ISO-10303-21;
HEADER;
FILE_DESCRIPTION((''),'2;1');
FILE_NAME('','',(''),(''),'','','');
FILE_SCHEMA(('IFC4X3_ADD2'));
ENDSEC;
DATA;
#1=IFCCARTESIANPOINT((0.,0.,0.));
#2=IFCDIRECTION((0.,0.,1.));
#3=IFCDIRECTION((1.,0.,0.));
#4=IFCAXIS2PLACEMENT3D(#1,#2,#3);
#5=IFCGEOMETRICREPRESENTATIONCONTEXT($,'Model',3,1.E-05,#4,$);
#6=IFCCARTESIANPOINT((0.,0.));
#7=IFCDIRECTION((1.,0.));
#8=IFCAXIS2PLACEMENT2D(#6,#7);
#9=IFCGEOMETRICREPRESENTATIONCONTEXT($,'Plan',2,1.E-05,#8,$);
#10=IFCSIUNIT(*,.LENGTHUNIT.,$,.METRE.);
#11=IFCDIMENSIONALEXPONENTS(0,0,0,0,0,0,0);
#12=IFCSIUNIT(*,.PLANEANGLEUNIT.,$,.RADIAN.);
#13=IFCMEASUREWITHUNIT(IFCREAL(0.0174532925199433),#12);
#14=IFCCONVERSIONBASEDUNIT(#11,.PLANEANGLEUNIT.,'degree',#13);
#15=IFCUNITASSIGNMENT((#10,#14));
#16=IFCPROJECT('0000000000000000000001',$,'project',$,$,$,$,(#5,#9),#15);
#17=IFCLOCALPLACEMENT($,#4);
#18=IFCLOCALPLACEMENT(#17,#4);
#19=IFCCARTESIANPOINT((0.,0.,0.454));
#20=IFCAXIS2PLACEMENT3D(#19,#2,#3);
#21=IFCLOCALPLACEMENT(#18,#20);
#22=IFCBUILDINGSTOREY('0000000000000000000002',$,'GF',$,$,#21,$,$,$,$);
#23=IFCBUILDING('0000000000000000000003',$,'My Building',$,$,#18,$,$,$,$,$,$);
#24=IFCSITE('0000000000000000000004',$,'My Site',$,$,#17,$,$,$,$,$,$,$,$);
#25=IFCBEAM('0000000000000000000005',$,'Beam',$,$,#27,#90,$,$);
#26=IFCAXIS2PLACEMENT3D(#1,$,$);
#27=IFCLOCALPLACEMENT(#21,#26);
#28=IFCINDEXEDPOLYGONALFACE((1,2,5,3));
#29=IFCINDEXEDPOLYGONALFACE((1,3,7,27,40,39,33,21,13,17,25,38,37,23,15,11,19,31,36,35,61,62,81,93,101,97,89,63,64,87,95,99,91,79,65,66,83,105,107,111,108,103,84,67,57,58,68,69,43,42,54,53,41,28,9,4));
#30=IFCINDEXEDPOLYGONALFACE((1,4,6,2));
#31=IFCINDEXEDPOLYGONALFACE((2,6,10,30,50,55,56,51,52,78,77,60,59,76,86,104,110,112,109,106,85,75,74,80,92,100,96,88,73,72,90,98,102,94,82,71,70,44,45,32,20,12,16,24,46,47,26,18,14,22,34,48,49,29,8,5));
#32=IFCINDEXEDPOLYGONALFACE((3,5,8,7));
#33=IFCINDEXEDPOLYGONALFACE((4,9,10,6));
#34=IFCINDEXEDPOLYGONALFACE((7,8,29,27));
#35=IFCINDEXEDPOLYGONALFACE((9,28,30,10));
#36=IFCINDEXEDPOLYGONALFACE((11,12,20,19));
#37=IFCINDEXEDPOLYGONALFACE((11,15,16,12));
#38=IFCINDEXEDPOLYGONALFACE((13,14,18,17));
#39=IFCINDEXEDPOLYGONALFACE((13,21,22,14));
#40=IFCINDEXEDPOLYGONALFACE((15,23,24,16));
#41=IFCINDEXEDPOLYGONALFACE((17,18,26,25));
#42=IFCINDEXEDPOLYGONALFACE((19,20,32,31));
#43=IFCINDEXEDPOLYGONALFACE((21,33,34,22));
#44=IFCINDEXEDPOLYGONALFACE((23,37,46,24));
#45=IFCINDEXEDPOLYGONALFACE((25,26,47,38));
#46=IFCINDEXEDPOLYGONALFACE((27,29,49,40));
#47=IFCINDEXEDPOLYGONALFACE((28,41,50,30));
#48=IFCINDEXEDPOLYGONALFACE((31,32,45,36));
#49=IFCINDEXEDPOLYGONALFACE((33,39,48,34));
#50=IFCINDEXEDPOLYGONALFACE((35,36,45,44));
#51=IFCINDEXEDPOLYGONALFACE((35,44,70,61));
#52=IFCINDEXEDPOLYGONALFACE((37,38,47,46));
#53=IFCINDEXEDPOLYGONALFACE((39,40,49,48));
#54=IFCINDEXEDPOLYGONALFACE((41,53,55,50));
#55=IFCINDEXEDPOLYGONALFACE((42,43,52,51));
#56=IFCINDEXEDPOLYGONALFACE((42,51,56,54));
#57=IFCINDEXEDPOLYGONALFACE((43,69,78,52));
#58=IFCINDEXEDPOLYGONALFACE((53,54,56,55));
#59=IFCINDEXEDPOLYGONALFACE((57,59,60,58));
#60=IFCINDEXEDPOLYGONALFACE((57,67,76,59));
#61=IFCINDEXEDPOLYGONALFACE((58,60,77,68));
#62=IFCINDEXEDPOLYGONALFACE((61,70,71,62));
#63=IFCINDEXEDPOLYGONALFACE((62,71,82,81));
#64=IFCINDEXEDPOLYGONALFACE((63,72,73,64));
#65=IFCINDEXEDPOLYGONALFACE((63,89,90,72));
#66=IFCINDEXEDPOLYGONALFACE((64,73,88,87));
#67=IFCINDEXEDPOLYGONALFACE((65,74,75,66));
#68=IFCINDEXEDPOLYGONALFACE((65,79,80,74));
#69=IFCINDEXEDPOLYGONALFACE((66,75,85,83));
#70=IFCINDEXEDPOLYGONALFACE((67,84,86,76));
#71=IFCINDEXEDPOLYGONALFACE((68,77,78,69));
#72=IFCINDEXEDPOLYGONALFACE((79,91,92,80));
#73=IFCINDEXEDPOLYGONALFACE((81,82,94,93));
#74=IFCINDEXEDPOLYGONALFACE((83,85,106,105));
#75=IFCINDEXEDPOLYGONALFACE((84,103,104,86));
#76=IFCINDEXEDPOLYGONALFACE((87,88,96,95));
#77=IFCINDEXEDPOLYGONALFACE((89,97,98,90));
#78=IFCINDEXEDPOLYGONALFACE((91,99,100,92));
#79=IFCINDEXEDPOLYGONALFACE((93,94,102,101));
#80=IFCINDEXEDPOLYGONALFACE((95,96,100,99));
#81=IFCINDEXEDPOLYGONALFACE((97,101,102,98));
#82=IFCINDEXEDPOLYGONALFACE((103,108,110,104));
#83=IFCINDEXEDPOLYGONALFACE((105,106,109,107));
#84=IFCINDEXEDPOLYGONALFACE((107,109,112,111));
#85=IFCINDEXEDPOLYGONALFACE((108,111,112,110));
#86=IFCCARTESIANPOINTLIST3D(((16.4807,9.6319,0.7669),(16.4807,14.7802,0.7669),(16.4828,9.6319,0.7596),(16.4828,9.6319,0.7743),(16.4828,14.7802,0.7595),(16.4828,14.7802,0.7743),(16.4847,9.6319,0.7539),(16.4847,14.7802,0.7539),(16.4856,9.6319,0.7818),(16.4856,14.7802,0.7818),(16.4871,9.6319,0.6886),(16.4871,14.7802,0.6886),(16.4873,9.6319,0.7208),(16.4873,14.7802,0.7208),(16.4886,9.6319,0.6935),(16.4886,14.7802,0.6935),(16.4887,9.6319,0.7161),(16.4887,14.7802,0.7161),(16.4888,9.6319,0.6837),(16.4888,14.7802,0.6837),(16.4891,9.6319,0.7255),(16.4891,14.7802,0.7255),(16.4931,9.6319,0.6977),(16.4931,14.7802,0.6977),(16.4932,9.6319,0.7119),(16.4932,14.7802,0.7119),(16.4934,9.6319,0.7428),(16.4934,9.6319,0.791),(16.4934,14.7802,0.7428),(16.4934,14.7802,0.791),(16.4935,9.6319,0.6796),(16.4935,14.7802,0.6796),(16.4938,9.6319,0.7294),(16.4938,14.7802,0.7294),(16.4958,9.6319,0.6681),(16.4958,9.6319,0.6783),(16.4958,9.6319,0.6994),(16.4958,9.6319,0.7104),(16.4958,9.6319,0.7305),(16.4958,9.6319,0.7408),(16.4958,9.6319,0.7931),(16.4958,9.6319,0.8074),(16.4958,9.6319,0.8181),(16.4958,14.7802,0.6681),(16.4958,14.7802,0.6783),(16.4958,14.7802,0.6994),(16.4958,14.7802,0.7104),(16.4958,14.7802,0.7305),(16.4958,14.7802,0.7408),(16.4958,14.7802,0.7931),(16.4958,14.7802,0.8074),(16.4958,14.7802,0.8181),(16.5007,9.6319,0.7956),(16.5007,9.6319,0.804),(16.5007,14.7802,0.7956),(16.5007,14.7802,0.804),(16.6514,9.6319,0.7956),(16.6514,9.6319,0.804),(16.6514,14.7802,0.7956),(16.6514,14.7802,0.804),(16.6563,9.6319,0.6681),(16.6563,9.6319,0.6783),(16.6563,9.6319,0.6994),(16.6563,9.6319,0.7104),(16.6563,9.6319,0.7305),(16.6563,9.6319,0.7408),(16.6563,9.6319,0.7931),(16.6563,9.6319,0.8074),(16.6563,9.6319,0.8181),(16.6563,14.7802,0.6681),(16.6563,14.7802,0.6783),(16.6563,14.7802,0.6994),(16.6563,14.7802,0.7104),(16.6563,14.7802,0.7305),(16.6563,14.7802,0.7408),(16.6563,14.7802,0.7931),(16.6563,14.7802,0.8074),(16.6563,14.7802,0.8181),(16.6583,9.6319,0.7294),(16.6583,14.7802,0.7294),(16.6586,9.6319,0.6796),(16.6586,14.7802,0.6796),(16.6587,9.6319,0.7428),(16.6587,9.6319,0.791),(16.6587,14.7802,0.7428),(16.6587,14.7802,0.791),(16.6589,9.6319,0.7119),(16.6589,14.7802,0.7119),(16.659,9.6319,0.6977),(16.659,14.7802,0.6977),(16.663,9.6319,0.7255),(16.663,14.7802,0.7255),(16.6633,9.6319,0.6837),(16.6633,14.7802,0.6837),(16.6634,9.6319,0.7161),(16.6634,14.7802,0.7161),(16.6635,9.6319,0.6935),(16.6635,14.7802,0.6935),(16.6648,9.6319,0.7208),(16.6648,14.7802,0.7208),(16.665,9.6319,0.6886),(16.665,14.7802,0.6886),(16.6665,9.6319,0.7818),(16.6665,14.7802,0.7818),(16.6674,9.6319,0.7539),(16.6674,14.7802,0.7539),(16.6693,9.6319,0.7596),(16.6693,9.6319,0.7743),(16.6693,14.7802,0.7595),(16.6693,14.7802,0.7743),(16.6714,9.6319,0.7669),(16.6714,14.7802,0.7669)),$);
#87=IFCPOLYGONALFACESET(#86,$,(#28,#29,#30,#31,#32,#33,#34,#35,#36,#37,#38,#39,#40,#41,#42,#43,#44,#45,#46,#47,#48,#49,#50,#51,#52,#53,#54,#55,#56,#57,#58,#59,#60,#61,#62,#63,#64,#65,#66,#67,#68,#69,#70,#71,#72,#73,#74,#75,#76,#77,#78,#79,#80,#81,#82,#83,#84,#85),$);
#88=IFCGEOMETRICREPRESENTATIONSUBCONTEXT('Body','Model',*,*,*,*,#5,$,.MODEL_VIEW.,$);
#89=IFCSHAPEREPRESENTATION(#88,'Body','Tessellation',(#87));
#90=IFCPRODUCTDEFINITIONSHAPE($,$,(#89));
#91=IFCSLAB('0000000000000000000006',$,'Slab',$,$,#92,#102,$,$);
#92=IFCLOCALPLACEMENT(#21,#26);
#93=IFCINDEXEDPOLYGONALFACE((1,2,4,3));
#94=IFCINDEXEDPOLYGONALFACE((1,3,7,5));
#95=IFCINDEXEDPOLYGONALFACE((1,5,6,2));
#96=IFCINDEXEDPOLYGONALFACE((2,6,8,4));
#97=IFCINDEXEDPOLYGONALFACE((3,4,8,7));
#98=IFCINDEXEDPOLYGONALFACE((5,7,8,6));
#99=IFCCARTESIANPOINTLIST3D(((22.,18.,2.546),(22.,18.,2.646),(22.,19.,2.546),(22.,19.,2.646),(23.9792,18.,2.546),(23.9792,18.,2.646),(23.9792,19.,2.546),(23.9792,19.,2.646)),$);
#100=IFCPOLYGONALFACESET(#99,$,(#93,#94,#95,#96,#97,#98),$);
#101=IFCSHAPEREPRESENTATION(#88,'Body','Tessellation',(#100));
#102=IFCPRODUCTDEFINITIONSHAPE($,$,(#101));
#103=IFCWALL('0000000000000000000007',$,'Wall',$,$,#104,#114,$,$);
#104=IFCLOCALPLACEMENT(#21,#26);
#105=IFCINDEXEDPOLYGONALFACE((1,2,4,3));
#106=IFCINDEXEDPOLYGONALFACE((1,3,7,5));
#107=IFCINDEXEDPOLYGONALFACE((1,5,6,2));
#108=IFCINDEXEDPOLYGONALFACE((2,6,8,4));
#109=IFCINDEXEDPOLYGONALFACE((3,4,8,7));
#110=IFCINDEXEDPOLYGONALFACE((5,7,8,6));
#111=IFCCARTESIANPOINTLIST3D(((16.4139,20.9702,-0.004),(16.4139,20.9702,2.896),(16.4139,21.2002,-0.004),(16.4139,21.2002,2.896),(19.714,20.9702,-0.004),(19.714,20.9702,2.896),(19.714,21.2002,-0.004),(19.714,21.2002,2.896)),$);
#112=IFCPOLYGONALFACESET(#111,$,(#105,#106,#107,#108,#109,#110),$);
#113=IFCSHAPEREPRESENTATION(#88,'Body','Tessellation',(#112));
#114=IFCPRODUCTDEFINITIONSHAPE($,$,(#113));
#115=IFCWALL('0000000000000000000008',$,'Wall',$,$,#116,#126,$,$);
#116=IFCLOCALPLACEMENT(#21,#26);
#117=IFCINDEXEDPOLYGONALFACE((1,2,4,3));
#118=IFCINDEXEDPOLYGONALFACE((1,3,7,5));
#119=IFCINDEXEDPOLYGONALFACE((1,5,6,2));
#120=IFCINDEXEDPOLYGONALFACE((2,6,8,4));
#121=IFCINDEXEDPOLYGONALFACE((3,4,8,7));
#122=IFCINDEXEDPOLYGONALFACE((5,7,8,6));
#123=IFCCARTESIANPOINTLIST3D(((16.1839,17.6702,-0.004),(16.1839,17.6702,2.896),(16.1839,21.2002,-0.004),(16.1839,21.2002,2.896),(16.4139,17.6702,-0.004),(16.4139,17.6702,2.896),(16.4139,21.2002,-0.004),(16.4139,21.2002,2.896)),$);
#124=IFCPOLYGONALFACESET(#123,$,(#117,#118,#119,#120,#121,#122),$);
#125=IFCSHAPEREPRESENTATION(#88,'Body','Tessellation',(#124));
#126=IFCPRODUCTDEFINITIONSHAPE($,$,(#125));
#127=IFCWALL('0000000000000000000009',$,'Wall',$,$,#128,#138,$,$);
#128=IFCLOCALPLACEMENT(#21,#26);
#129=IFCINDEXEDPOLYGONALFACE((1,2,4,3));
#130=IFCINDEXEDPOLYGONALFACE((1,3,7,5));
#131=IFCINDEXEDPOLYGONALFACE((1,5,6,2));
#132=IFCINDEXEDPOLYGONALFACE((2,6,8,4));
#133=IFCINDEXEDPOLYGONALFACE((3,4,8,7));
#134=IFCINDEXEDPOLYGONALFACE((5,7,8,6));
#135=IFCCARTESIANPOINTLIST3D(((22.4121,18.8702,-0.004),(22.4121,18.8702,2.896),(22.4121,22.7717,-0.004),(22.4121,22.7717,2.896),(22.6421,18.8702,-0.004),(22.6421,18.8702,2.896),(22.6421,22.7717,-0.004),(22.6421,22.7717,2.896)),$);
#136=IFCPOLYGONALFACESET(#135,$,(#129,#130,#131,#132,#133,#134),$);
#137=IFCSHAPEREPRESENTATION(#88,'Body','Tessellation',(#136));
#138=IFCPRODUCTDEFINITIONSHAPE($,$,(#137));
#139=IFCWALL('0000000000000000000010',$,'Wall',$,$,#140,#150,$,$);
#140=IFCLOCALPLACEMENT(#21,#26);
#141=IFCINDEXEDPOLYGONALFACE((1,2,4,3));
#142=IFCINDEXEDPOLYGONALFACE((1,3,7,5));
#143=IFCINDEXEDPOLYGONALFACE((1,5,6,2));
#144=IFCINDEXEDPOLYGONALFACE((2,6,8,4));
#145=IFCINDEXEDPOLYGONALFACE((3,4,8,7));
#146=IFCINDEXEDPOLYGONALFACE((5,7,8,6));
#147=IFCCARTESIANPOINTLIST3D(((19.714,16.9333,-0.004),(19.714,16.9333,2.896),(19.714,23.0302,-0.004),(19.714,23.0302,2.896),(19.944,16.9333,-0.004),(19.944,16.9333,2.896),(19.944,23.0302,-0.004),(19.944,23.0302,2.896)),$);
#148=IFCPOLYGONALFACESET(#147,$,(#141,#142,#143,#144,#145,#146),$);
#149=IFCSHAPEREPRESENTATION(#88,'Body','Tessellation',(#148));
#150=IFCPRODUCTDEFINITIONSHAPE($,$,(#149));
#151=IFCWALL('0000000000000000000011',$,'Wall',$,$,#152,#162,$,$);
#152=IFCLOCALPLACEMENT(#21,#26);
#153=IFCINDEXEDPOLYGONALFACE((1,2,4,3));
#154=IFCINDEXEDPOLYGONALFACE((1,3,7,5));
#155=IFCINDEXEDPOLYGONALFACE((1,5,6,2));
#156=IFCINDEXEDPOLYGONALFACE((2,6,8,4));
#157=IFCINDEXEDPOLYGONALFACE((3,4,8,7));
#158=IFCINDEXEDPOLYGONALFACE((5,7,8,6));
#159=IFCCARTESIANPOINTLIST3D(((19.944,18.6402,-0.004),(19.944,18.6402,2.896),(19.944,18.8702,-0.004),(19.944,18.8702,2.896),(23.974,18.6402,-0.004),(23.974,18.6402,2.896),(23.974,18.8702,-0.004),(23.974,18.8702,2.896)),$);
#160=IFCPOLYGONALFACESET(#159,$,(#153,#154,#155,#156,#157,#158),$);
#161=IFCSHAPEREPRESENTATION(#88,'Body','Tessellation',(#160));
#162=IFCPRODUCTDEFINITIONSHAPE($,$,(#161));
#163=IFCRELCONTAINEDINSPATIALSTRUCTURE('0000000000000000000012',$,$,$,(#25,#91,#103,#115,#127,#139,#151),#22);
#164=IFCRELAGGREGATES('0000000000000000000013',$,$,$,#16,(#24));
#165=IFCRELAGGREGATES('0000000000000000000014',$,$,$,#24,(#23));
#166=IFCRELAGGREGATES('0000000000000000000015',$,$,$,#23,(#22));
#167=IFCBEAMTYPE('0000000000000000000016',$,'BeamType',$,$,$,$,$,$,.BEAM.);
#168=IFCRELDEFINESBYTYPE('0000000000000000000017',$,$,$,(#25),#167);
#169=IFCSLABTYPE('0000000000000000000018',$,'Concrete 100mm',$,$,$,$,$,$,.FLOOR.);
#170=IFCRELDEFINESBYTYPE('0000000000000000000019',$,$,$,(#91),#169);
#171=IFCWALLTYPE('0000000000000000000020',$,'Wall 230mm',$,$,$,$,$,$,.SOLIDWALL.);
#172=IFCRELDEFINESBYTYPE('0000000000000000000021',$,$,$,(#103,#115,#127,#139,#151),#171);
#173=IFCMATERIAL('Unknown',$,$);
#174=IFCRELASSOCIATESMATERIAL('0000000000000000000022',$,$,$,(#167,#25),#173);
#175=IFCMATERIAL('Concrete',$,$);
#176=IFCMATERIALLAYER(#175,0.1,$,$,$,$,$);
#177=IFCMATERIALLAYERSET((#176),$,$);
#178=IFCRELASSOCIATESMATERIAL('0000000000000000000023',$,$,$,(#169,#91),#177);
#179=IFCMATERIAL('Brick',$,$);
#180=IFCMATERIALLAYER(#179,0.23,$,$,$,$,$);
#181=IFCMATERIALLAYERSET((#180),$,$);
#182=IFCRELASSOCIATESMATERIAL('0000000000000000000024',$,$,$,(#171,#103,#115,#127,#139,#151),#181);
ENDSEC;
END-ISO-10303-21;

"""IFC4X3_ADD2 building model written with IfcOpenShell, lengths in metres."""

from ifc_helpers import new_model, entity, si_unit, converted_unit, frame, origin_with_axes, origin_2d_with_axis, place, context, subcontext, project, spatial, line, indexed_curve, outline, extrude, material, layer, layer_set, layer_usage, material_profile, profile_set, profile_usage, type_object, element, save


model = new_model("IFC4X3_ADD2")

# Units and contexts
model_context = context("Model", 3, precision=1e-05, world=origin_with_axes())
plan_context = context("Plan", 2, precision=1e-05, world=origin_2d_with_axis())
body_context_1 = subcontext(model_context, "Body", "Model", "MODEL_VIEW")
ifc_project = project(units=[si_unit("LENGTHUNIT", "METRE"), converted_unit("PLANEANGLEUNIT", "degree", entity("IfcReal", 0.0174532925199433), si_unit("PLANEANGLEUNIT", "RADIAN"), dimensions=[0, 0, 0, 0, 0, 0, 0])], contexts=[model_context, plan_context])

# Site, building, storey
site_placement = place(None, origin_with_axes())
site = spatial("IfcSite", under=ifc_project, at=site_placement, Name="My Site")
building_placement = place(site_placement, origin_with_axes())
building = spatial("IfcBuilding", under=site, at=building_placement, Name="My Building")
storey_placement = place(building_placement, frame((0.0, 0.0, 0.454), z_axis=(0.0, 0.0, 1.0), x_axis=(1.0, 0.0, 0.0)))
storey = spatial("IfcBuildingStorey", under=building, at=storey_placement, Name="GF")

# Beam
ifc_material_1 = material(Name="Unknown")
ifc_material_profile = material_profile(ifc_material_1, outline(indexed_curve([(0.0803, 0.0102), (0.0826, 0.0116), (0.0872, 0.0156), (0.0889, 0.0205), (0.0874, 0.0254), (0.083, 0.0297), (0.0803, 0.0314), (0.0803, 0.0423), (0.0828, 0.0439), (0.0873, 0.048), (0.0888, 0.0528), (0.087, 0.0574), (0.0822, 0.0613), (0.0803, 0.0624), (0.0803, 0.0727), (0.0827, 0.0747), (0.0914, 0.0858), (0.0933, 0.0915), (0.0953, 0.0989), (0.0933, 0.1062), (0.0904, 0.1137), (0.0827, 0.123), (0.0803, 0.125), (0.0754, 0.1276), (0.0754, 0.1359), (0.0803, 0.1393), (0.0803, 0.15), (-0.0803, 0.15), (-0.0803, 0.1393), (-0.0754, 0.1359), (-0.0754, 0.1276), (-0.0803, 0.125), (-0.0827, 0.123), (-0.0904, 0.1137), (-0.0933, 0.1062), (-0.0953, 0.0989), (-0.0933, 0.0915), (-0.0914, 0.0858), (-0.0827, 0.0747), (-0.0803, 0.0727), (-0.0803, 0.0624), (-0.0822, 0.0613), (-0.087, 0.0574), (-0.0888, 0.0528), (-0.0873, 0.048), (-0.0828, 0.0439), (-0.0803, 0.0423), (-0.0803, 0.0314), (-0.083, 0.0297), (-0.0874, 0.0254), (-0.0889, 0.0205), (-0.0872, 0.0157), (-0.0826, 0.0116), (-0.0803, 0.0102), (-0.0803, 0.0), (0.0803, 0.0), (0.0803, 0.0102)])))
ifc_profile_set = profile_set([ifc_material_profile])
ifc_profile_usage = profile_usage(ifc_profile_set, cardinal=5)
beam_type = type_object("IfcBeamType", Name="BeamType", PredefinedType="BEAM", material=ifc_profile_set)
beam_placement = place(storey_placement, frame((16.576, 14.7802, 0.6681), z_axis=(0.0, -1.0, 0.0), x_axis=(1.0, 0.0, 0.0)))
element("IfcBeam", 1, at=beam_placement, inside=storey, type_object=beam_type, material=ifc_profile_usage, Name="Beam", context=body_context_1, shape_type="SweptSolid", body=[
    extrude(outline(indexed_curve([(0.0803, 0.0102), (0.0826, 0.0116), (0.0872, 0.0156), (0.0889, 0.0205), (0.0874, 0.0254), (0.083, 0.0297), (0.0803, 0.0314), (0.0803, 0.0423), (0.0828, 0.0439), (0.0873, 0.048), (0.0888, 0.0528), (0.087, 0.0574), (0.0822, 0.0613), (0.0803, 0.0624), (0.0803, 0.0727), (0.0827, 0.0747), (0.0914, 0.0858), (0.0933, 0.0915), (0.0953, 0.0989), (0.0933, 0.1062), (0.0904, 0.1137), (0.0827, 0.123), (0.0803, 0.125), (0.0754, 0.1276), (0.0754, 0.1359), (0.0803, 0.1393), (0.0803, 0.15), (-0.0803, 0.15), (-0.0803, 0.1393), (-0.0754, 0.1359), (-0.0754, 0.1276), (-0.0803, 0.125), (-0.0827, 0.123), (-0.0904, 0.1137), (-0.0933, 0.1062), (-0.0953, 0.0989), (-0.0933, 0.0915), (-0.0914, 0.0858), (-0.0827, 0.0747), (-0.0803, 0.0727), (-0.0803, 0.0624), (-0.0822, 0.0613), (-0.087, 0.0574), (-0.0888, 0.0528), (-0.0873, 0.048), (-0.0828, 0.0439), (-0.0803, 0.0423), (-0.0803, 0.0314), (-0.083, 0.0297), (-0.0874, 0.0254), (-0.0889, 0.0205), (-0.0872, 0.0157), (-0.0826, 0.0116), (-0.0803, 0.0102), (-0.0803, 0.0), (0.0803, 0.0), (0.0803, 0.0102)])), origin_with_axes(), (0.0, 0.0, 1.0), 5.1484),
])

# Slab
ifc_material_2 = material(Name="Concrete")
ifc_layer_1 = layer(ifc_material_2, 0.1)
ifc_layer_set_1 = layer_set([ifc_layer_1])
slab_type_1 = type_object("IfcSlabType", Name="Concrete 100mm", PredefinedType="FLOOR", material=ifc_layer_set_1)
ifc_layer_usage_1 = layer_usage(ifc_layer_set_1, "AXIS3", "POSITIVE", 0.0)
slab_1_placement = place(storey_placement, frame((22.0, 18.0, 2.546), z_axis=(0.0, 0.0, 1.0), x_axis=(1.0, 0.0, 0.0)))
element("IfcSlab", 2, at=slab_1_placement, inside=storey, type_object=slab_type_1, material=ifc_layer_usage_1, Name="Slab", context=body_context_1, shape_type="SweptSolid", body=[
    extrude(outline(indexed_curve([(0.0, 0.0), (1.9792, 0.0), (1.9792, 1.0), (0.0, 1.0)], segments=[line(4, 1), line(1, 2), line(2, 3), line(3, 4)], self_intersect=False)), None, (0.0, 0.0, 1.0), 0.1),
])

# Walls
ifc_material_3 = material(Name="Brick")
ifc_layer_2 = layer(ifc_material_3, 0.23)
ifc_layer_set_2 = layer_set([ifc_layer_2])
ifc_layer_usage_2 = layer_usage(ifc_layer_set_2, "AXIS2", "POSITIVE", 0.0)
wall_type = type_object("IfcWallType", Name="Wall 230mm", PredefinedType="SOLIDWALL", material=ifc_layer_set_2)
wall_1_placement = place(storey_placement, frame((19.714, 21.2002, -0.004), z_axis=(0.0, 0.0, 1.0), x_axis=(-1.0, 0.0, 0.0)))
element("IfcWall", 3, at=wall_1_placement, inside=storey, type_object=wall_type, material=ifc_layer_usage_2, Name="Wall", context=body_context_1, shape_type="SweptSolid", body=[
    extrude(outline(indexed_curve([(0.0, 0.0), (0.0, 0.23), (3.3, 0.23), (3.3, 0.0), (0.0, 0.0)], self_intersect=False)), origin_with_axes(), (0.0, 0.0, 1.0), 2.9),
])
ifc_layer_usage_3 = layer_usage(ifc_layer_set_2, "AXIS2", "POSITIVE", 0.0)
wall_2_placement = place(storey_placement, frame((16.4139, 17.6702, -0.004), z_axis=(0.0, 0.0, 1.0), x_axis=(0.000001, 1.0, 0.0)))
element("IfcWall", 4, at=wall_2_placement, inside=storey, type_object=wall_type, material=ifc_layer_usage_3, Name="Wall", context=body_context_1, shape_type="SweptSolid", body=[
    extrude(outline(indexed_curve([(0.0, 0.0), (0.0, 0.23), (3.53, 0.23), (3.53, 0.0), (0.0, 0.0)], self_intersect=False)), origin_with_axes(), (0.0, 0.0, 1.0), 2.9),
])
ifc_layer_usage_4 = layer_usage(ifc_layer_set_2, "AXIS2", "POSITIVE", 0.0)
wall_3_placement = place(storey_placement, frame((22.6421, 18.8702, -0.004), z_axis=(0.0, 0.0, 1.0), x_axis=(0.000001, 1.0, 0.0)))
element("IfcWall", 5, at=wall_3_placement, inside=storey, type_object=wall_type, material=ifc_layer_usage_4, Name="Wall", context=body_context_1, shape_type="SweptSolid", body=[
    extrude(outline(indexed_curve([(0.0, 0.0), (0.0, 0.23), (3.9015, 0.23), (3.9015, 0.0), (0.0, 0.0)], self_intersect=False)), origin_with_axes(), (0.0, 0.0, 1.0), 2.9),
])
ifc_layer_usage_5 = layer_usage(ifc_layer_set_2, "AXIS2", "POSITIVE", 0.0)
wall_4_placement = place(storey_placement, frame((19.944, 16.9333, -0.004), z_axis=(0.0, 0.0, 1.0), x_axis=(0.000001, 1.0, 0.0)))
element("IfcWall", 6, at=wall_4_placement, inside=storey, type_object=wall_type, material=ifc_layer_usage_5, Name="Wall", context=body_context_1, shape_type="SweptSolid", body=[
    extrude(outline(indexed_curve([(0.0, 0.0), (0.0, 0.23), (6.0969, 0.23), (6.0969, 0.0), (0.0, 0.0)], self_intersect=False)), origin_with_axes(), (0.0, 0.0, 1.0), 2.9),
])
ifc_layer_usage_6 = layer_usage(ifc_layer_set_2, "AXIS2", "POSITIVE", 0.0)
wall_5_placement = place(storey_placement, frame((23.974, 18.8702, -0.004), z_axis=(0.0, 0.0, 1.0), x_axis=(-1.0, 0.0, 0.0)))
element("IfcWall", 7, at=wall_5_placement, inside=storey, type_object=wall_type, material=ifc_layer_usage_6, Name="Wall", context=body_context_1, shape_type="SweptSolid", body=[
    extrude(outline(indexed_curve([(0.0, 0.0), (0.0, 0.23), (4.03, 0.23), (4.03, 0.0), (0.0, 0.0)], self_intersect=False)), origin_with_axes(), (0.0, 0.0, 1.0), 2.9),
])

save(model, "model.ifc")
